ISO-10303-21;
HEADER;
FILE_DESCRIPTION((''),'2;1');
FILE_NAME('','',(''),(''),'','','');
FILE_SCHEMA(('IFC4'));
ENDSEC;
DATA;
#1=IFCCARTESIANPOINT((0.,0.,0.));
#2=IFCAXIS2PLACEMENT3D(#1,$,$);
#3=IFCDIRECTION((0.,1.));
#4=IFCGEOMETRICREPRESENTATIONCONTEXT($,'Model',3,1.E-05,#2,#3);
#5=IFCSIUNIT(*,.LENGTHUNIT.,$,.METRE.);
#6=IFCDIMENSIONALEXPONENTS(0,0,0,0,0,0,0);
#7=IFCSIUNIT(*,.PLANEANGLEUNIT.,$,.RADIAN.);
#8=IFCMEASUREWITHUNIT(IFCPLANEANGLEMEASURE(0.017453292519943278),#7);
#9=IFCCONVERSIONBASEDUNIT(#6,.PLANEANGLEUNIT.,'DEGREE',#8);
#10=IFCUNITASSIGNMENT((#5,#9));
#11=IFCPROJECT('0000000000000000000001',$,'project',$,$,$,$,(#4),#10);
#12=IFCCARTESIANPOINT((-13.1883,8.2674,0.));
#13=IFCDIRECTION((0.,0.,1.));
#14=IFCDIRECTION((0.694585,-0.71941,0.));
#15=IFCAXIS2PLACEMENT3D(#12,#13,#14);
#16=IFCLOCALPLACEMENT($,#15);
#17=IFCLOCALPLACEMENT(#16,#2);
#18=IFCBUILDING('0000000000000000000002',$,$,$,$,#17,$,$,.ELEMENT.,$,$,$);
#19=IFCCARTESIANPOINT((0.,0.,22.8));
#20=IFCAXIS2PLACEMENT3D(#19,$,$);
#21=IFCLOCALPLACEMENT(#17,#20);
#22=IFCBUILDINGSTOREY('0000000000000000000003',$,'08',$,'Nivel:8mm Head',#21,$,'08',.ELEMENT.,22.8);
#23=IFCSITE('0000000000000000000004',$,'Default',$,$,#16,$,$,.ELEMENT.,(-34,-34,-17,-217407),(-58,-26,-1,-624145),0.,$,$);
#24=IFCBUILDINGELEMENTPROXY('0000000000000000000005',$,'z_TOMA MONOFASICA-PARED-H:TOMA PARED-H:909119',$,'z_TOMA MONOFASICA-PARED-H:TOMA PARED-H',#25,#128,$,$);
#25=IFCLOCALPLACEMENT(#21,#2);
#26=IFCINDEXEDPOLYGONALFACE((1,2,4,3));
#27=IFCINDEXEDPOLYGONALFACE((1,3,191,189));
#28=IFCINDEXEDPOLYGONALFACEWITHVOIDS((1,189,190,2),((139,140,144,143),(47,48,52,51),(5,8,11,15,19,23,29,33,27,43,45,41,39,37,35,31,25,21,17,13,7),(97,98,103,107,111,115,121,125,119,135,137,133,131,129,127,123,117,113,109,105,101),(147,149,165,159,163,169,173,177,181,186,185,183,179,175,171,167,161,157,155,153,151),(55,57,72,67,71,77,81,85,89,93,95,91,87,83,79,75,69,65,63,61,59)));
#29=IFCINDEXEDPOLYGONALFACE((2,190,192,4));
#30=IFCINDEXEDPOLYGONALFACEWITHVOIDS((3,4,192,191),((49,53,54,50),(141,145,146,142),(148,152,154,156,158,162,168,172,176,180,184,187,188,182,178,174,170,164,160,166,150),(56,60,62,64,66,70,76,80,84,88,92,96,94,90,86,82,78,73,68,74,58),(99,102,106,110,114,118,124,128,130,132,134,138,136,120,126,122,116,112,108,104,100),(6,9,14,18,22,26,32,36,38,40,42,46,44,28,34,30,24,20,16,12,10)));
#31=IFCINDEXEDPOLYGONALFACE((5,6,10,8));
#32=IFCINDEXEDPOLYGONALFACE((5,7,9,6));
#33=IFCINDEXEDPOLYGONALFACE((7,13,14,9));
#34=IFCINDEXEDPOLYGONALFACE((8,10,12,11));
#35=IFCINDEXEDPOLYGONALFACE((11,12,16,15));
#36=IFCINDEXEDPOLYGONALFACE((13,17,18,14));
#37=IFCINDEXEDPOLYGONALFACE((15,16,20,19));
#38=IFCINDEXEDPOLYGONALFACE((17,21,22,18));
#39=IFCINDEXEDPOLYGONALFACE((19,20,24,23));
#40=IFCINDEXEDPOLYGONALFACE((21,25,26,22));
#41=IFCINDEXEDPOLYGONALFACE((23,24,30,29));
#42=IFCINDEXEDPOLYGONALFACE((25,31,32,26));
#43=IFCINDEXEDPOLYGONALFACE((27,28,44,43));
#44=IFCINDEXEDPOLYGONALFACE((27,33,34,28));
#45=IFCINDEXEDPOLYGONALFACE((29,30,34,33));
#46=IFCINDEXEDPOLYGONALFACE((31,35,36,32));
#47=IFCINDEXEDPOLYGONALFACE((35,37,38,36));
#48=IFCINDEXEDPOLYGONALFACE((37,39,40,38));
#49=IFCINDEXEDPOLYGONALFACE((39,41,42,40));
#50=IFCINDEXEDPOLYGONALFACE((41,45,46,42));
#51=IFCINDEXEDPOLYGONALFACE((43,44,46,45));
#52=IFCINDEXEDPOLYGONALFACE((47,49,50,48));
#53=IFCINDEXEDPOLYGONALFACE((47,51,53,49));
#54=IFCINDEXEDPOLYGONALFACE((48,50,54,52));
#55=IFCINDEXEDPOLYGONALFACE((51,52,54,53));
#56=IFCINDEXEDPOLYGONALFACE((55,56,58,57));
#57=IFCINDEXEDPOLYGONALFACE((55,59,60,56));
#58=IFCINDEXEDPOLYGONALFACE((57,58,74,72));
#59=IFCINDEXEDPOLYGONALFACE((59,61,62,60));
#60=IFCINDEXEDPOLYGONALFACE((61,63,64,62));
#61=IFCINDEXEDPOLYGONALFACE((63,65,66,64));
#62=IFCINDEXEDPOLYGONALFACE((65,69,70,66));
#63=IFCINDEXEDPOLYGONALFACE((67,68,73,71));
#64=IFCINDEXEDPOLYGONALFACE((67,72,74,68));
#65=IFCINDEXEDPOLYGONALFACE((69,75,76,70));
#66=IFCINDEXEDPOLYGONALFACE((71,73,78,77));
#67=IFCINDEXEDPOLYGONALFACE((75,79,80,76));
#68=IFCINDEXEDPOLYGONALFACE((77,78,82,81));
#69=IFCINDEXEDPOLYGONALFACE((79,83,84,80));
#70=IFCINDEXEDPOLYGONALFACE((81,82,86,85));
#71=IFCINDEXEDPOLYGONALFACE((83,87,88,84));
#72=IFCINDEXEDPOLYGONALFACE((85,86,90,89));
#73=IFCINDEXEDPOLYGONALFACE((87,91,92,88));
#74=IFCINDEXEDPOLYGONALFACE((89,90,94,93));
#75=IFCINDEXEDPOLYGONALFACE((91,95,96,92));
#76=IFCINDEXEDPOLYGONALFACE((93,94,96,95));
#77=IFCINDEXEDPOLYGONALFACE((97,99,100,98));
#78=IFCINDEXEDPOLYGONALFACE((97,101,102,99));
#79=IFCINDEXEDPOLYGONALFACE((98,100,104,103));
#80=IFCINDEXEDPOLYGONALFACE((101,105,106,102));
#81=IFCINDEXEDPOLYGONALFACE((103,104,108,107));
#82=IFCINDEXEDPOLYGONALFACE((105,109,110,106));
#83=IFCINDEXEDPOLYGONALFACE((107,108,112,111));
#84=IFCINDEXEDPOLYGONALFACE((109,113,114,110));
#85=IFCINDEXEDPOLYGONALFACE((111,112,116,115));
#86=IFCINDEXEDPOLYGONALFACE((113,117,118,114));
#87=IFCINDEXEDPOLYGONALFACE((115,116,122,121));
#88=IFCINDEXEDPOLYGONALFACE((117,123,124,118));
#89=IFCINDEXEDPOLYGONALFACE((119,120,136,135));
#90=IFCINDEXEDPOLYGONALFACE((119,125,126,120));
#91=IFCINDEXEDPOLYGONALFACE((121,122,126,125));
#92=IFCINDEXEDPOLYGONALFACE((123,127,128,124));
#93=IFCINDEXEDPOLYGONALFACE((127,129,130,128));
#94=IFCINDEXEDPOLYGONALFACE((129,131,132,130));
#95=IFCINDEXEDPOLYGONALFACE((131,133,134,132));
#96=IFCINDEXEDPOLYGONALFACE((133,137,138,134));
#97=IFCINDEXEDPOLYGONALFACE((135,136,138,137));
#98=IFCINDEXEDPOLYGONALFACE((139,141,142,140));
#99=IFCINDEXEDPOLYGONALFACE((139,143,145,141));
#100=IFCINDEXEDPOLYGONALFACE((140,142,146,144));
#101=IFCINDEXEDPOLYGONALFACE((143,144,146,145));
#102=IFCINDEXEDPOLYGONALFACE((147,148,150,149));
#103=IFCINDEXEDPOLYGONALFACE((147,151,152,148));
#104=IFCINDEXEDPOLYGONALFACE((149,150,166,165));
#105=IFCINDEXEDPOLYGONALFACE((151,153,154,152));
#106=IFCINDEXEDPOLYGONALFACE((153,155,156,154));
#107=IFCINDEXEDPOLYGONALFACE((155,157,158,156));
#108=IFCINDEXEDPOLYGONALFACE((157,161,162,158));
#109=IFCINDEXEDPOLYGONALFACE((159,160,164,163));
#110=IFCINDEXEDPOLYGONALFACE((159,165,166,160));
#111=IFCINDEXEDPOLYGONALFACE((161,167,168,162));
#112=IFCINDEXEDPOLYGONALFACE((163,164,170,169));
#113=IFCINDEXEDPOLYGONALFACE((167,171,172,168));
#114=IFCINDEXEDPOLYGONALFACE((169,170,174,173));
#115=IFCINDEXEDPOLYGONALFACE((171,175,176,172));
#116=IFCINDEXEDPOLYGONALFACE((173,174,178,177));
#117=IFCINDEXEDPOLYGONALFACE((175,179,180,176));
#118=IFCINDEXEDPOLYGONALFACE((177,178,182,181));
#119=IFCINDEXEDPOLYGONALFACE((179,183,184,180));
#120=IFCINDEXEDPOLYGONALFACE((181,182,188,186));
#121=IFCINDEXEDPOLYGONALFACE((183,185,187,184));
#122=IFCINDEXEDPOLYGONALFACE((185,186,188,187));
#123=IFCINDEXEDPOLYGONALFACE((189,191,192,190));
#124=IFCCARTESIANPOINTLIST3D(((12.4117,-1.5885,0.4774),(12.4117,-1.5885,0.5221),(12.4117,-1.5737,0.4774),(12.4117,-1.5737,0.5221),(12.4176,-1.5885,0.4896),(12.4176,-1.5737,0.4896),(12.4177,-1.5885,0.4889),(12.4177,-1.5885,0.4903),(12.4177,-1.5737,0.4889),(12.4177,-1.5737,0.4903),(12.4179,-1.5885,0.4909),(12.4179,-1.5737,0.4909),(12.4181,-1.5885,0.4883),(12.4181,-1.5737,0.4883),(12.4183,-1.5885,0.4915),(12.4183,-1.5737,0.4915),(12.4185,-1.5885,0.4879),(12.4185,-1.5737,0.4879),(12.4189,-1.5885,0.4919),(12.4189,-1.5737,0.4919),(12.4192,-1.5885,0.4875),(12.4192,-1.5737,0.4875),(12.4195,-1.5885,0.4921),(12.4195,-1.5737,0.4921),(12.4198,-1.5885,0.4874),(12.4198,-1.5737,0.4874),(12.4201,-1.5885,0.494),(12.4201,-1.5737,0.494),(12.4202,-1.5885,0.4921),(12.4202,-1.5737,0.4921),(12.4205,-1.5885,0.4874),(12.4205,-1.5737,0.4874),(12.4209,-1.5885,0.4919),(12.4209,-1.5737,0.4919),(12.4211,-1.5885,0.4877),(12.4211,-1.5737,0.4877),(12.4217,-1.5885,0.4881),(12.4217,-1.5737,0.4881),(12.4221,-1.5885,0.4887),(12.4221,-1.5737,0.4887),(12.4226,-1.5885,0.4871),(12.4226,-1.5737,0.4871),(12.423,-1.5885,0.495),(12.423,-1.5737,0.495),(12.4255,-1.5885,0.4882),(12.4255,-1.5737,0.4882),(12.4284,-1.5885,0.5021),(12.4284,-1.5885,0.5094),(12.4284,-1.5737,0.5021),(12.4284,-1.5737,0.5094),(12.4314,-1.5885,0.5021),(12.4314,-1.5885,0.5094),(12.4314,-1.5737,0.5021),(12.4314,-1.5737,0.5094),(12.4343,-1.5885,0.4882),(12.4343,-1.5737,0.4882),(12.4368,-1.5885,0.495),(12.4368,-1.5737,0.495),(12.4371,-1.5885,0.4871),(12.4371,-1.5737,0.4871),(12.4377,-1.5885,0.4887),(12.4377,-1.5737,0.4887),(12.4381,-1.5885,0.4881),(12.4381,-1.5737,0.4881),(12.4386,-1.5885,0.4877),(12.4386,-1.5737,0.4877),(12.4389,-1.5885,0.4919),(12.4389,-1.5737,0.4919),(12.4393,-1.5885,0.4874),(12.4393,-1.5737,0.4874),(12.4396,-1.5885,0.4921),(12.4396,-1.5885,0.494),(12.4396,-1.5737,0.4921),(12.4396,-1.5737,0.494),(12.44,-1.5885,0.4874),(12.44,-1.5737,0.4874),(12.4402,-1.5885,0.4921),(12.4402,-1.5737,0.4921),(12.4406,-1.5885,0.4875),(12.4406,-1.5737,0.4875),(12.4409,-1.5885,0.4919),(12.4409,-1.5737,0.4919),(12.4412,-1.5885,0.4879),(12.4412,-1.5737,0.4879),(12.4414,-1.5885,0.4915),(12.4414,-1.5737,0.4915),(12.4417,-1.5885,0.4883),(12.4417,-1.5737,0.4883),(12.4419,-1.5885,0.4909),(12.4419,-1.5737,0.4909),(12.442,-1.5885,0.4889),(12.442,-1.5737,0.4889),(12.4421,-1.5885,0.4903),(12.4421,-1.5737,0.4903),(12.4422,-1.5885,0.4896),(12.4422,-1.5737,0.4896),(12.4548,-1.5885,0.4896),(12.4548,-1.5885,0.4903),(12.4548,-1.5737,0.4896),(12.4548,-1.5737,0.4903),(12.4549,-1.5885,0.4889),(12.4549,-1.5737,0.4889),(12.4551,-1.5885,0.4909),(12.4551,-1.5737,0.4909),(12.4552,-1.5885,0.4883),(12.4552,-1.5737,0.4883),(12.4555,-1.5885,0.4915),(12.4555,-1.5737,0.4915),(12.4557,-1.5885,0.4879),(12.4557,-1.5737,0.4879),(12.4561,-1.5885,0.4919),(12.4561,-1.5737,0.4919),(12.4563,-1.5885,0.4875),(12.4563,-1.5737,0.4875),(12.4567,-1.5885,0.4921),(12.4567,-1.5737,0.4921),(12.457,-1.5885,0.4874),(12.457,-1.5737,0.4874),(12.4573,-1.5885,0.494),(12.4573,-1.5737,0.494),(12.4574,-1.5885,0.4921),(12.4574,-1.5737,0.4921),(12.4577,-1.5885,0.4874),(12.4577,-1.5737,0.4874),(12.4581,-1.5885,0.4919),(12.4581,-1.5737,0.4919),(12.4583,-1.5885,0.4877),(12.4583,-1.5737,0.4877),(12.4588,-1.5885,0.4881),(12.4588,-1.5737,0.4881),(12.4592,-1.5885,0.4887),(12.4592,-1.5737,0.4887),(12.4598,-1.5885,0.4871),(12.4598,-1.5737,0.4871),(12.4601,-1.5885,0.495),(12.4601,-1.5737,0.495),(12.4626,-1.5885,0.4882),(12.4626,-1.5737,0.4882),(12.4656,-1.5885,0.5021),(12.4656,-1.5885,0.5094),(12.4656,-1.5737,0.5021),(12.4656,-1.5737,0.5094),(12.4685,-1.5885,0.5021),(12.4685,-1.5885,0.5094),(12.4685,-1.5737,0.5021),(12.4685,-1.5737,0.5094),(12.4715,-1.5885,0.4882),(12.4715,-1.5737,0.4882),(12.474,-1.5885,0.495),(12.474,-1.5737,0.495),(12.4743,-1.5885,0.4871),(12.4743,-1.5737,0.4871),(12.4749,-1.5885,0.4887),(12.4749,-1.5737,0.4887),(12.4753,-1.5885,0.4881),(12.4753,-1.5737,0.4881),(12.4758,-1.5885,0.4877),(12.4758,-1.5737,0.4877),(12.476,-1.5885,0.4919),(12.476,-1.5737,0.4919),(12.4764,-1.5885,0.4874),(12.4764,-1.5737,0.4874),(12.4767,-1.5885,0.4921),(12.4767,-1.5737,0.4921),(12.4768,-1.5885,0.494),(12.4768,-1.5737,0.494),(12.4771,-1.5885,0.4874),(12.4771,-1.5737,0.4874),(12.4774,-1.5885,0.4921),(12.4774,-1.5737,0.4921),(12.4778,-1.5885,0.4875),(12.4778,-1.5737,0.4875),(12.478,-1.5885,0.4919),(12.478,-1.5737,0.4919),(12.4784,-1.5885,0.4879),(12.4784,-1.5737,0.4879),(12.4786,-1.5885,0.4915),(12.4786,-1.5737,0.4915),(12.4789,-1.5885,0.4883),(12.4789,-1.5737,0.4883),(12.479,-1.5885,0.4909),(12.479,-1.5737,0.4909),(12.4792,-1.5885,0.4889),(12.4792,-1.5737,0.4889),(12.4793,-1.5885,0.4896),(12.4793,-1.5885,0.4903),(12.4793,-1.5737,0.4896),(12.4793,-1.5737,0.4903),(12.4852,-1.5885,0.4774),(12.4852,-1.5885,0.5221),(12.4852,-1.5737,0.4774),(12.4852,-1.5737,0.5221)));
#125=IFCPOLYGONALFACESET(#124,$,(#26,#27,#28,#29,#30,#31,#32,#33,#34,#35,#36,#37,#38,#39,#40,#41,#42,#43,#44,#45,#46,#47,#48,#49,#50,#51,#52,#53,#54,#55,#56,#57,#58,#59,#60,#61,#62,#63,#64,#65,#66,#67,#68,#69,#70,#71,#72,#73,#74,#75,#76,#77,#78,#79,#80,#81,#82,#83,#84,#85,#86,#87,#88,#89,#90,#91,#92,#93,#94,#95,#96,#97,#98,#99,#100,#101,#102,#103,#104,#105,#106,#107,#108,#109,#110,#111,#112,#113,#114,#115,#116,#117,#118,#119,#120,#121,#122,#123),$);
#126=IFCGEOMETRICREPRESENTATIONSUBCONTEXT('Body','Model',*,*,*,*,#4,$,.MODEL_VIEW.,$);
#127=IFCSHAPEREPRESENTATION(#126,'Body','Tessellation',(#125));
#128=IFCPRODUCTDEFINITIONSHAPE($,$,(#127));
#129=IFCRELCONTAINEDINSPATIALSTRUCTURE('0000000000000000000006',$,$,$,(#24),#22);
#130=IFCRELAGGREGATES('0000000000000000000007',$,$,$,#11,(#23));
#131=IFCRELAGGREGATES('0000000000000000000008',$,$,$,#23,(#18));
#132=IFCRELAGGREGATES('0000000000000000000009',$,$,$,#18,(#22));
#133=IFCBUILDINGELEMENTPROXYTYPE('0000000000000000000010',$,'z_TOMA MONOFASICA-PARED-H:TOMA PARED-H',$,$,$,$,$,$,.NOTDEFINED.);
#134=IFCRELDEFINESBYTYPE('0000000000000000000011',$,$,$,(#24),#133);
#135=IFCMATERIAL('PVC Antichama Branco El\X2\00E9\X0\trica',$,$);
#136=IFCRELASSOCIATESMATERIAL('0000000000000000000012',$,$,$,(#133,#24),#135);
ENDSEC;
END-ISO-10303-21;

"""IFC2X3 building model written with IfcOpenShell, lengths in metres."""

from ifc_helpers import new_model, entity, si_unit, converted_unit, direction, frame, frame_2d, origin, place, context, subcontext, project, spatial, polyline, circle_curve, parameter, trimmed, segment, composite_curve, outline, extrude, source, transform, mapped, material, type_object, type_shapes, element, save


model = new_model("IFC2X3")

# Units and contexts
model_context = context("Model", 3, precision=1e-05, world=origin(), true_north=direction((0.0, 1.0)))
body_context = subcontext(model_context, "Body", "Model", "MODEL_VIEW")
ifc_project = project(units=[si_unit("LENGTHUNIT", "METRE"), converted_unit("PLANEANGLEUNIT", "DEGREE", entity("IfcPlaneAngleMeasure", 0.017453292519943278), si_unit("PLANEANGLEUNIT", "RADIAN"), dimensions=[0, 0, 0, 0, 0, 0, 0])], contexts=[model_context])

# Site, building, storey
site_placement = place(None, frame((-13.1883, 8.2674, 0.0), z_axis=(0.0, 0.0, 1.0), x_axis=(0.694585, -0.71941, 0.0)))
site = spatial("IfcSite", under=ifc_project, at=site_placement, Name="Default", CompositionType="ELEMENT", RefLatitude=(-34, -34, -17, -217407), RefLongitude=(-58, -26, -1, -624145), RefElevation=0.0)
building_placement = place(site_placement, origin())
building = spatial("IfcBuilding", under=site, at=building_placement, CompositionType="ELEMENT")
storey_placement = place(building_placement, frame((0.0, 0.0, 22.8)))
storey = spatial("IfcBuildingStorey", under=building, at=storey_placement, Name="08", ObjectType="Nivel:8mm Head", LongName="08", CompositionType="ELEMENT", Elevation=22.8)

# Building element proxy
ifc_material_1 = material(Name="PVC Antichama Branco Elétrica")
building_element_proxy_type_1 = type_object("IfcBuildingElementProxyType", Name="z_TOMA MONOFASICA-PARED-H:TOMA PARED-H", PredefinedType="NOTDEFINED", material=ifc_material_1)
shared_shape_1 = source(origin(), body_context, "Body", "SweptSolid", [
    extrude(outline(polyline([(-0.0368, -0.0223), (0.0368, -0.0223), (0.0368, 0.0223), (-0.0368, 0.0223), (-0.0368, -0.0223)]), holes=[composite_curve([segment(polyline([(0.0141, 0.0115), (0.0116, 0.0047)]), True, "CONTINUOUS"), segment(polyline([(0.0116, 0.0047), (0.0088, 0.0057)]), True, "CONTINUOUS"), segment(polyline([(0.0088, 0.0057), (0.0096, 0.0078)]), True, "CONTINUOUS"), segment(trimmed(circle_curve(frame_2d((0.0087, 0.0099), x_axis=(1.0, 0.0)), 0.0024), [parameter(27.118901)], [parameter(292.881099)], True, "PARAMETER"), False, "CONTINUOUS"), segment(polyline([(0.0108, 0.011), (0.0113, 0.0126)]), True, "CONTINUOUS"), segment(polyline([(0.0113, 0.0126), (0.0141, 0.0115)]), True, "CONTINUOUS")], self_intersect=False), composite_curve([segment(polyline([(0.0255, 0.0047), (0.023, 0.0115)]), True, "CONTINUOUS"), segment(polyline([(0.023, 0.0115), (0.0258, 0.0126)]), True, "CONTINUOUS"), segment(polyline([(0.0258, 0.0126), (0.0264, 0.011)]), True, "CONTINUOUS"), segment(trimmed(circle_curve(frame_2d((0.0285, 0.0099), x_axis=(1.0, 0.0)), 0.0024), [parameter(247.118901)], [parameter(152.881099)], True, "PARAMETER"), False, "CONTINUOUS"), segment(polyline([(0.0276, 0.0078), (0.0283, 0.0057)]), True, "CONTINUOUS"), segment(polyline([(0.0283, 0.0057), (0.0255, 0.0047)]), True, "CONTINUOUS")], self_intersect=False), polyline([(0.0201, -0.0024), (0.0201, -0.0097), (0.0171, -0.0097), (0.0171, -0.0024), (0.0201, -0.0024)]), composite_curve([segment(polyline([(-0.0141, 0.0115), (-0.0113, 0.0126)]), True, "CONTINUOUS"), segment(polyline([(-0.0113, 0.0126), (-0.0108, 0.011)]), True, "CONTINUOUS"), segment(trimmed(circle_curve(frame_2d((-0.0087, 0.0099), x_axis=(1.0, 0.0)), 0.0024), [parameter(247.118901)], [parameter(152.881099)], True, "PARAMETER"), False, "CONTINUOUS"), segment(polyline([(-0.0096, 0.0078), (-0.0088, 0.0057)]), True, "CONTINUOUS"), segment(polyline([(-0.0088, 0.0057), (-0.0116, 0.0047)]), True, "CONTINUOUS"), segment(polyline([(-0.0116, 0.0047), (-0.0141, 0.0115)]), True, "CONTINUOUS")], self_intersect=False), composite_curve([segment(polyline([(-0.0255, 0.0047), (-0.0283, 0.0057)]), True, "CONTINUOUS"), segment(polyline([(-0.0283, 0.0057), (-0.0276, 0.0078)]), True, "CONTINUOUS"), segment(trimmed(circle_curve(frame_2d((-0.0285, 0.0099), x_axis=(1.0, 0.0)), 0.0024), [parameter(27.118901)], [parameter(292.881099)], True, "PARAMETER"), False, "CONTINUOUS"), segment(polyline([(-0.0264, 0.011), (-0.0258, 0.0126)]), True, "CONTINUOUS"), segment(polyline([(-0.0258, 0.0126), (-0.023, 0.0115)]), True, "CONTINUOUS"), segment(polyline([(-0.023, 0.0115), (-0.0255, 0.0047)]), True, "CONTINUOUS")], self_intersect=False), polyline([(-0.0201, -0.0024), (-0.0171, -0.0024), (-0.0171, -0.0097), (-0.0201, -0.0097), (-0.0201, -0.0024)])]), frame((0.0, -0.005, 0.0223), z_axis=(0.0, 1.0, 0.0), x_axis=(1.0, 0.0, 0.0)), (0.0, 0.0, 1.0), 0.0148),
])
type_shapes(building_element_proxy_type_1, [shared_shape_1])
proxy_1_placement = place(storey_placement, frame((12.4485, -1.5835, 0.4774)))
element("IfcBuildingElementProxy", 1, at=proxy_1_placement, inside=storey, type_object=building_element_proxy_type_1, material=ifc_material_1, Name="z_TOMA MONOFASICA-PARED-H:TOMA PARED-H:909119", ObjectType="z_TOMA MONOFASICA-PARED-H:TOMA PARED-H", context=body_context, shape_type="MappedRepresentation", body=[
    mapped(shared_shape_1, transform((0.0, 0.0, 0.0), scale=1.0)),
])

save(model, "model.ifc")
